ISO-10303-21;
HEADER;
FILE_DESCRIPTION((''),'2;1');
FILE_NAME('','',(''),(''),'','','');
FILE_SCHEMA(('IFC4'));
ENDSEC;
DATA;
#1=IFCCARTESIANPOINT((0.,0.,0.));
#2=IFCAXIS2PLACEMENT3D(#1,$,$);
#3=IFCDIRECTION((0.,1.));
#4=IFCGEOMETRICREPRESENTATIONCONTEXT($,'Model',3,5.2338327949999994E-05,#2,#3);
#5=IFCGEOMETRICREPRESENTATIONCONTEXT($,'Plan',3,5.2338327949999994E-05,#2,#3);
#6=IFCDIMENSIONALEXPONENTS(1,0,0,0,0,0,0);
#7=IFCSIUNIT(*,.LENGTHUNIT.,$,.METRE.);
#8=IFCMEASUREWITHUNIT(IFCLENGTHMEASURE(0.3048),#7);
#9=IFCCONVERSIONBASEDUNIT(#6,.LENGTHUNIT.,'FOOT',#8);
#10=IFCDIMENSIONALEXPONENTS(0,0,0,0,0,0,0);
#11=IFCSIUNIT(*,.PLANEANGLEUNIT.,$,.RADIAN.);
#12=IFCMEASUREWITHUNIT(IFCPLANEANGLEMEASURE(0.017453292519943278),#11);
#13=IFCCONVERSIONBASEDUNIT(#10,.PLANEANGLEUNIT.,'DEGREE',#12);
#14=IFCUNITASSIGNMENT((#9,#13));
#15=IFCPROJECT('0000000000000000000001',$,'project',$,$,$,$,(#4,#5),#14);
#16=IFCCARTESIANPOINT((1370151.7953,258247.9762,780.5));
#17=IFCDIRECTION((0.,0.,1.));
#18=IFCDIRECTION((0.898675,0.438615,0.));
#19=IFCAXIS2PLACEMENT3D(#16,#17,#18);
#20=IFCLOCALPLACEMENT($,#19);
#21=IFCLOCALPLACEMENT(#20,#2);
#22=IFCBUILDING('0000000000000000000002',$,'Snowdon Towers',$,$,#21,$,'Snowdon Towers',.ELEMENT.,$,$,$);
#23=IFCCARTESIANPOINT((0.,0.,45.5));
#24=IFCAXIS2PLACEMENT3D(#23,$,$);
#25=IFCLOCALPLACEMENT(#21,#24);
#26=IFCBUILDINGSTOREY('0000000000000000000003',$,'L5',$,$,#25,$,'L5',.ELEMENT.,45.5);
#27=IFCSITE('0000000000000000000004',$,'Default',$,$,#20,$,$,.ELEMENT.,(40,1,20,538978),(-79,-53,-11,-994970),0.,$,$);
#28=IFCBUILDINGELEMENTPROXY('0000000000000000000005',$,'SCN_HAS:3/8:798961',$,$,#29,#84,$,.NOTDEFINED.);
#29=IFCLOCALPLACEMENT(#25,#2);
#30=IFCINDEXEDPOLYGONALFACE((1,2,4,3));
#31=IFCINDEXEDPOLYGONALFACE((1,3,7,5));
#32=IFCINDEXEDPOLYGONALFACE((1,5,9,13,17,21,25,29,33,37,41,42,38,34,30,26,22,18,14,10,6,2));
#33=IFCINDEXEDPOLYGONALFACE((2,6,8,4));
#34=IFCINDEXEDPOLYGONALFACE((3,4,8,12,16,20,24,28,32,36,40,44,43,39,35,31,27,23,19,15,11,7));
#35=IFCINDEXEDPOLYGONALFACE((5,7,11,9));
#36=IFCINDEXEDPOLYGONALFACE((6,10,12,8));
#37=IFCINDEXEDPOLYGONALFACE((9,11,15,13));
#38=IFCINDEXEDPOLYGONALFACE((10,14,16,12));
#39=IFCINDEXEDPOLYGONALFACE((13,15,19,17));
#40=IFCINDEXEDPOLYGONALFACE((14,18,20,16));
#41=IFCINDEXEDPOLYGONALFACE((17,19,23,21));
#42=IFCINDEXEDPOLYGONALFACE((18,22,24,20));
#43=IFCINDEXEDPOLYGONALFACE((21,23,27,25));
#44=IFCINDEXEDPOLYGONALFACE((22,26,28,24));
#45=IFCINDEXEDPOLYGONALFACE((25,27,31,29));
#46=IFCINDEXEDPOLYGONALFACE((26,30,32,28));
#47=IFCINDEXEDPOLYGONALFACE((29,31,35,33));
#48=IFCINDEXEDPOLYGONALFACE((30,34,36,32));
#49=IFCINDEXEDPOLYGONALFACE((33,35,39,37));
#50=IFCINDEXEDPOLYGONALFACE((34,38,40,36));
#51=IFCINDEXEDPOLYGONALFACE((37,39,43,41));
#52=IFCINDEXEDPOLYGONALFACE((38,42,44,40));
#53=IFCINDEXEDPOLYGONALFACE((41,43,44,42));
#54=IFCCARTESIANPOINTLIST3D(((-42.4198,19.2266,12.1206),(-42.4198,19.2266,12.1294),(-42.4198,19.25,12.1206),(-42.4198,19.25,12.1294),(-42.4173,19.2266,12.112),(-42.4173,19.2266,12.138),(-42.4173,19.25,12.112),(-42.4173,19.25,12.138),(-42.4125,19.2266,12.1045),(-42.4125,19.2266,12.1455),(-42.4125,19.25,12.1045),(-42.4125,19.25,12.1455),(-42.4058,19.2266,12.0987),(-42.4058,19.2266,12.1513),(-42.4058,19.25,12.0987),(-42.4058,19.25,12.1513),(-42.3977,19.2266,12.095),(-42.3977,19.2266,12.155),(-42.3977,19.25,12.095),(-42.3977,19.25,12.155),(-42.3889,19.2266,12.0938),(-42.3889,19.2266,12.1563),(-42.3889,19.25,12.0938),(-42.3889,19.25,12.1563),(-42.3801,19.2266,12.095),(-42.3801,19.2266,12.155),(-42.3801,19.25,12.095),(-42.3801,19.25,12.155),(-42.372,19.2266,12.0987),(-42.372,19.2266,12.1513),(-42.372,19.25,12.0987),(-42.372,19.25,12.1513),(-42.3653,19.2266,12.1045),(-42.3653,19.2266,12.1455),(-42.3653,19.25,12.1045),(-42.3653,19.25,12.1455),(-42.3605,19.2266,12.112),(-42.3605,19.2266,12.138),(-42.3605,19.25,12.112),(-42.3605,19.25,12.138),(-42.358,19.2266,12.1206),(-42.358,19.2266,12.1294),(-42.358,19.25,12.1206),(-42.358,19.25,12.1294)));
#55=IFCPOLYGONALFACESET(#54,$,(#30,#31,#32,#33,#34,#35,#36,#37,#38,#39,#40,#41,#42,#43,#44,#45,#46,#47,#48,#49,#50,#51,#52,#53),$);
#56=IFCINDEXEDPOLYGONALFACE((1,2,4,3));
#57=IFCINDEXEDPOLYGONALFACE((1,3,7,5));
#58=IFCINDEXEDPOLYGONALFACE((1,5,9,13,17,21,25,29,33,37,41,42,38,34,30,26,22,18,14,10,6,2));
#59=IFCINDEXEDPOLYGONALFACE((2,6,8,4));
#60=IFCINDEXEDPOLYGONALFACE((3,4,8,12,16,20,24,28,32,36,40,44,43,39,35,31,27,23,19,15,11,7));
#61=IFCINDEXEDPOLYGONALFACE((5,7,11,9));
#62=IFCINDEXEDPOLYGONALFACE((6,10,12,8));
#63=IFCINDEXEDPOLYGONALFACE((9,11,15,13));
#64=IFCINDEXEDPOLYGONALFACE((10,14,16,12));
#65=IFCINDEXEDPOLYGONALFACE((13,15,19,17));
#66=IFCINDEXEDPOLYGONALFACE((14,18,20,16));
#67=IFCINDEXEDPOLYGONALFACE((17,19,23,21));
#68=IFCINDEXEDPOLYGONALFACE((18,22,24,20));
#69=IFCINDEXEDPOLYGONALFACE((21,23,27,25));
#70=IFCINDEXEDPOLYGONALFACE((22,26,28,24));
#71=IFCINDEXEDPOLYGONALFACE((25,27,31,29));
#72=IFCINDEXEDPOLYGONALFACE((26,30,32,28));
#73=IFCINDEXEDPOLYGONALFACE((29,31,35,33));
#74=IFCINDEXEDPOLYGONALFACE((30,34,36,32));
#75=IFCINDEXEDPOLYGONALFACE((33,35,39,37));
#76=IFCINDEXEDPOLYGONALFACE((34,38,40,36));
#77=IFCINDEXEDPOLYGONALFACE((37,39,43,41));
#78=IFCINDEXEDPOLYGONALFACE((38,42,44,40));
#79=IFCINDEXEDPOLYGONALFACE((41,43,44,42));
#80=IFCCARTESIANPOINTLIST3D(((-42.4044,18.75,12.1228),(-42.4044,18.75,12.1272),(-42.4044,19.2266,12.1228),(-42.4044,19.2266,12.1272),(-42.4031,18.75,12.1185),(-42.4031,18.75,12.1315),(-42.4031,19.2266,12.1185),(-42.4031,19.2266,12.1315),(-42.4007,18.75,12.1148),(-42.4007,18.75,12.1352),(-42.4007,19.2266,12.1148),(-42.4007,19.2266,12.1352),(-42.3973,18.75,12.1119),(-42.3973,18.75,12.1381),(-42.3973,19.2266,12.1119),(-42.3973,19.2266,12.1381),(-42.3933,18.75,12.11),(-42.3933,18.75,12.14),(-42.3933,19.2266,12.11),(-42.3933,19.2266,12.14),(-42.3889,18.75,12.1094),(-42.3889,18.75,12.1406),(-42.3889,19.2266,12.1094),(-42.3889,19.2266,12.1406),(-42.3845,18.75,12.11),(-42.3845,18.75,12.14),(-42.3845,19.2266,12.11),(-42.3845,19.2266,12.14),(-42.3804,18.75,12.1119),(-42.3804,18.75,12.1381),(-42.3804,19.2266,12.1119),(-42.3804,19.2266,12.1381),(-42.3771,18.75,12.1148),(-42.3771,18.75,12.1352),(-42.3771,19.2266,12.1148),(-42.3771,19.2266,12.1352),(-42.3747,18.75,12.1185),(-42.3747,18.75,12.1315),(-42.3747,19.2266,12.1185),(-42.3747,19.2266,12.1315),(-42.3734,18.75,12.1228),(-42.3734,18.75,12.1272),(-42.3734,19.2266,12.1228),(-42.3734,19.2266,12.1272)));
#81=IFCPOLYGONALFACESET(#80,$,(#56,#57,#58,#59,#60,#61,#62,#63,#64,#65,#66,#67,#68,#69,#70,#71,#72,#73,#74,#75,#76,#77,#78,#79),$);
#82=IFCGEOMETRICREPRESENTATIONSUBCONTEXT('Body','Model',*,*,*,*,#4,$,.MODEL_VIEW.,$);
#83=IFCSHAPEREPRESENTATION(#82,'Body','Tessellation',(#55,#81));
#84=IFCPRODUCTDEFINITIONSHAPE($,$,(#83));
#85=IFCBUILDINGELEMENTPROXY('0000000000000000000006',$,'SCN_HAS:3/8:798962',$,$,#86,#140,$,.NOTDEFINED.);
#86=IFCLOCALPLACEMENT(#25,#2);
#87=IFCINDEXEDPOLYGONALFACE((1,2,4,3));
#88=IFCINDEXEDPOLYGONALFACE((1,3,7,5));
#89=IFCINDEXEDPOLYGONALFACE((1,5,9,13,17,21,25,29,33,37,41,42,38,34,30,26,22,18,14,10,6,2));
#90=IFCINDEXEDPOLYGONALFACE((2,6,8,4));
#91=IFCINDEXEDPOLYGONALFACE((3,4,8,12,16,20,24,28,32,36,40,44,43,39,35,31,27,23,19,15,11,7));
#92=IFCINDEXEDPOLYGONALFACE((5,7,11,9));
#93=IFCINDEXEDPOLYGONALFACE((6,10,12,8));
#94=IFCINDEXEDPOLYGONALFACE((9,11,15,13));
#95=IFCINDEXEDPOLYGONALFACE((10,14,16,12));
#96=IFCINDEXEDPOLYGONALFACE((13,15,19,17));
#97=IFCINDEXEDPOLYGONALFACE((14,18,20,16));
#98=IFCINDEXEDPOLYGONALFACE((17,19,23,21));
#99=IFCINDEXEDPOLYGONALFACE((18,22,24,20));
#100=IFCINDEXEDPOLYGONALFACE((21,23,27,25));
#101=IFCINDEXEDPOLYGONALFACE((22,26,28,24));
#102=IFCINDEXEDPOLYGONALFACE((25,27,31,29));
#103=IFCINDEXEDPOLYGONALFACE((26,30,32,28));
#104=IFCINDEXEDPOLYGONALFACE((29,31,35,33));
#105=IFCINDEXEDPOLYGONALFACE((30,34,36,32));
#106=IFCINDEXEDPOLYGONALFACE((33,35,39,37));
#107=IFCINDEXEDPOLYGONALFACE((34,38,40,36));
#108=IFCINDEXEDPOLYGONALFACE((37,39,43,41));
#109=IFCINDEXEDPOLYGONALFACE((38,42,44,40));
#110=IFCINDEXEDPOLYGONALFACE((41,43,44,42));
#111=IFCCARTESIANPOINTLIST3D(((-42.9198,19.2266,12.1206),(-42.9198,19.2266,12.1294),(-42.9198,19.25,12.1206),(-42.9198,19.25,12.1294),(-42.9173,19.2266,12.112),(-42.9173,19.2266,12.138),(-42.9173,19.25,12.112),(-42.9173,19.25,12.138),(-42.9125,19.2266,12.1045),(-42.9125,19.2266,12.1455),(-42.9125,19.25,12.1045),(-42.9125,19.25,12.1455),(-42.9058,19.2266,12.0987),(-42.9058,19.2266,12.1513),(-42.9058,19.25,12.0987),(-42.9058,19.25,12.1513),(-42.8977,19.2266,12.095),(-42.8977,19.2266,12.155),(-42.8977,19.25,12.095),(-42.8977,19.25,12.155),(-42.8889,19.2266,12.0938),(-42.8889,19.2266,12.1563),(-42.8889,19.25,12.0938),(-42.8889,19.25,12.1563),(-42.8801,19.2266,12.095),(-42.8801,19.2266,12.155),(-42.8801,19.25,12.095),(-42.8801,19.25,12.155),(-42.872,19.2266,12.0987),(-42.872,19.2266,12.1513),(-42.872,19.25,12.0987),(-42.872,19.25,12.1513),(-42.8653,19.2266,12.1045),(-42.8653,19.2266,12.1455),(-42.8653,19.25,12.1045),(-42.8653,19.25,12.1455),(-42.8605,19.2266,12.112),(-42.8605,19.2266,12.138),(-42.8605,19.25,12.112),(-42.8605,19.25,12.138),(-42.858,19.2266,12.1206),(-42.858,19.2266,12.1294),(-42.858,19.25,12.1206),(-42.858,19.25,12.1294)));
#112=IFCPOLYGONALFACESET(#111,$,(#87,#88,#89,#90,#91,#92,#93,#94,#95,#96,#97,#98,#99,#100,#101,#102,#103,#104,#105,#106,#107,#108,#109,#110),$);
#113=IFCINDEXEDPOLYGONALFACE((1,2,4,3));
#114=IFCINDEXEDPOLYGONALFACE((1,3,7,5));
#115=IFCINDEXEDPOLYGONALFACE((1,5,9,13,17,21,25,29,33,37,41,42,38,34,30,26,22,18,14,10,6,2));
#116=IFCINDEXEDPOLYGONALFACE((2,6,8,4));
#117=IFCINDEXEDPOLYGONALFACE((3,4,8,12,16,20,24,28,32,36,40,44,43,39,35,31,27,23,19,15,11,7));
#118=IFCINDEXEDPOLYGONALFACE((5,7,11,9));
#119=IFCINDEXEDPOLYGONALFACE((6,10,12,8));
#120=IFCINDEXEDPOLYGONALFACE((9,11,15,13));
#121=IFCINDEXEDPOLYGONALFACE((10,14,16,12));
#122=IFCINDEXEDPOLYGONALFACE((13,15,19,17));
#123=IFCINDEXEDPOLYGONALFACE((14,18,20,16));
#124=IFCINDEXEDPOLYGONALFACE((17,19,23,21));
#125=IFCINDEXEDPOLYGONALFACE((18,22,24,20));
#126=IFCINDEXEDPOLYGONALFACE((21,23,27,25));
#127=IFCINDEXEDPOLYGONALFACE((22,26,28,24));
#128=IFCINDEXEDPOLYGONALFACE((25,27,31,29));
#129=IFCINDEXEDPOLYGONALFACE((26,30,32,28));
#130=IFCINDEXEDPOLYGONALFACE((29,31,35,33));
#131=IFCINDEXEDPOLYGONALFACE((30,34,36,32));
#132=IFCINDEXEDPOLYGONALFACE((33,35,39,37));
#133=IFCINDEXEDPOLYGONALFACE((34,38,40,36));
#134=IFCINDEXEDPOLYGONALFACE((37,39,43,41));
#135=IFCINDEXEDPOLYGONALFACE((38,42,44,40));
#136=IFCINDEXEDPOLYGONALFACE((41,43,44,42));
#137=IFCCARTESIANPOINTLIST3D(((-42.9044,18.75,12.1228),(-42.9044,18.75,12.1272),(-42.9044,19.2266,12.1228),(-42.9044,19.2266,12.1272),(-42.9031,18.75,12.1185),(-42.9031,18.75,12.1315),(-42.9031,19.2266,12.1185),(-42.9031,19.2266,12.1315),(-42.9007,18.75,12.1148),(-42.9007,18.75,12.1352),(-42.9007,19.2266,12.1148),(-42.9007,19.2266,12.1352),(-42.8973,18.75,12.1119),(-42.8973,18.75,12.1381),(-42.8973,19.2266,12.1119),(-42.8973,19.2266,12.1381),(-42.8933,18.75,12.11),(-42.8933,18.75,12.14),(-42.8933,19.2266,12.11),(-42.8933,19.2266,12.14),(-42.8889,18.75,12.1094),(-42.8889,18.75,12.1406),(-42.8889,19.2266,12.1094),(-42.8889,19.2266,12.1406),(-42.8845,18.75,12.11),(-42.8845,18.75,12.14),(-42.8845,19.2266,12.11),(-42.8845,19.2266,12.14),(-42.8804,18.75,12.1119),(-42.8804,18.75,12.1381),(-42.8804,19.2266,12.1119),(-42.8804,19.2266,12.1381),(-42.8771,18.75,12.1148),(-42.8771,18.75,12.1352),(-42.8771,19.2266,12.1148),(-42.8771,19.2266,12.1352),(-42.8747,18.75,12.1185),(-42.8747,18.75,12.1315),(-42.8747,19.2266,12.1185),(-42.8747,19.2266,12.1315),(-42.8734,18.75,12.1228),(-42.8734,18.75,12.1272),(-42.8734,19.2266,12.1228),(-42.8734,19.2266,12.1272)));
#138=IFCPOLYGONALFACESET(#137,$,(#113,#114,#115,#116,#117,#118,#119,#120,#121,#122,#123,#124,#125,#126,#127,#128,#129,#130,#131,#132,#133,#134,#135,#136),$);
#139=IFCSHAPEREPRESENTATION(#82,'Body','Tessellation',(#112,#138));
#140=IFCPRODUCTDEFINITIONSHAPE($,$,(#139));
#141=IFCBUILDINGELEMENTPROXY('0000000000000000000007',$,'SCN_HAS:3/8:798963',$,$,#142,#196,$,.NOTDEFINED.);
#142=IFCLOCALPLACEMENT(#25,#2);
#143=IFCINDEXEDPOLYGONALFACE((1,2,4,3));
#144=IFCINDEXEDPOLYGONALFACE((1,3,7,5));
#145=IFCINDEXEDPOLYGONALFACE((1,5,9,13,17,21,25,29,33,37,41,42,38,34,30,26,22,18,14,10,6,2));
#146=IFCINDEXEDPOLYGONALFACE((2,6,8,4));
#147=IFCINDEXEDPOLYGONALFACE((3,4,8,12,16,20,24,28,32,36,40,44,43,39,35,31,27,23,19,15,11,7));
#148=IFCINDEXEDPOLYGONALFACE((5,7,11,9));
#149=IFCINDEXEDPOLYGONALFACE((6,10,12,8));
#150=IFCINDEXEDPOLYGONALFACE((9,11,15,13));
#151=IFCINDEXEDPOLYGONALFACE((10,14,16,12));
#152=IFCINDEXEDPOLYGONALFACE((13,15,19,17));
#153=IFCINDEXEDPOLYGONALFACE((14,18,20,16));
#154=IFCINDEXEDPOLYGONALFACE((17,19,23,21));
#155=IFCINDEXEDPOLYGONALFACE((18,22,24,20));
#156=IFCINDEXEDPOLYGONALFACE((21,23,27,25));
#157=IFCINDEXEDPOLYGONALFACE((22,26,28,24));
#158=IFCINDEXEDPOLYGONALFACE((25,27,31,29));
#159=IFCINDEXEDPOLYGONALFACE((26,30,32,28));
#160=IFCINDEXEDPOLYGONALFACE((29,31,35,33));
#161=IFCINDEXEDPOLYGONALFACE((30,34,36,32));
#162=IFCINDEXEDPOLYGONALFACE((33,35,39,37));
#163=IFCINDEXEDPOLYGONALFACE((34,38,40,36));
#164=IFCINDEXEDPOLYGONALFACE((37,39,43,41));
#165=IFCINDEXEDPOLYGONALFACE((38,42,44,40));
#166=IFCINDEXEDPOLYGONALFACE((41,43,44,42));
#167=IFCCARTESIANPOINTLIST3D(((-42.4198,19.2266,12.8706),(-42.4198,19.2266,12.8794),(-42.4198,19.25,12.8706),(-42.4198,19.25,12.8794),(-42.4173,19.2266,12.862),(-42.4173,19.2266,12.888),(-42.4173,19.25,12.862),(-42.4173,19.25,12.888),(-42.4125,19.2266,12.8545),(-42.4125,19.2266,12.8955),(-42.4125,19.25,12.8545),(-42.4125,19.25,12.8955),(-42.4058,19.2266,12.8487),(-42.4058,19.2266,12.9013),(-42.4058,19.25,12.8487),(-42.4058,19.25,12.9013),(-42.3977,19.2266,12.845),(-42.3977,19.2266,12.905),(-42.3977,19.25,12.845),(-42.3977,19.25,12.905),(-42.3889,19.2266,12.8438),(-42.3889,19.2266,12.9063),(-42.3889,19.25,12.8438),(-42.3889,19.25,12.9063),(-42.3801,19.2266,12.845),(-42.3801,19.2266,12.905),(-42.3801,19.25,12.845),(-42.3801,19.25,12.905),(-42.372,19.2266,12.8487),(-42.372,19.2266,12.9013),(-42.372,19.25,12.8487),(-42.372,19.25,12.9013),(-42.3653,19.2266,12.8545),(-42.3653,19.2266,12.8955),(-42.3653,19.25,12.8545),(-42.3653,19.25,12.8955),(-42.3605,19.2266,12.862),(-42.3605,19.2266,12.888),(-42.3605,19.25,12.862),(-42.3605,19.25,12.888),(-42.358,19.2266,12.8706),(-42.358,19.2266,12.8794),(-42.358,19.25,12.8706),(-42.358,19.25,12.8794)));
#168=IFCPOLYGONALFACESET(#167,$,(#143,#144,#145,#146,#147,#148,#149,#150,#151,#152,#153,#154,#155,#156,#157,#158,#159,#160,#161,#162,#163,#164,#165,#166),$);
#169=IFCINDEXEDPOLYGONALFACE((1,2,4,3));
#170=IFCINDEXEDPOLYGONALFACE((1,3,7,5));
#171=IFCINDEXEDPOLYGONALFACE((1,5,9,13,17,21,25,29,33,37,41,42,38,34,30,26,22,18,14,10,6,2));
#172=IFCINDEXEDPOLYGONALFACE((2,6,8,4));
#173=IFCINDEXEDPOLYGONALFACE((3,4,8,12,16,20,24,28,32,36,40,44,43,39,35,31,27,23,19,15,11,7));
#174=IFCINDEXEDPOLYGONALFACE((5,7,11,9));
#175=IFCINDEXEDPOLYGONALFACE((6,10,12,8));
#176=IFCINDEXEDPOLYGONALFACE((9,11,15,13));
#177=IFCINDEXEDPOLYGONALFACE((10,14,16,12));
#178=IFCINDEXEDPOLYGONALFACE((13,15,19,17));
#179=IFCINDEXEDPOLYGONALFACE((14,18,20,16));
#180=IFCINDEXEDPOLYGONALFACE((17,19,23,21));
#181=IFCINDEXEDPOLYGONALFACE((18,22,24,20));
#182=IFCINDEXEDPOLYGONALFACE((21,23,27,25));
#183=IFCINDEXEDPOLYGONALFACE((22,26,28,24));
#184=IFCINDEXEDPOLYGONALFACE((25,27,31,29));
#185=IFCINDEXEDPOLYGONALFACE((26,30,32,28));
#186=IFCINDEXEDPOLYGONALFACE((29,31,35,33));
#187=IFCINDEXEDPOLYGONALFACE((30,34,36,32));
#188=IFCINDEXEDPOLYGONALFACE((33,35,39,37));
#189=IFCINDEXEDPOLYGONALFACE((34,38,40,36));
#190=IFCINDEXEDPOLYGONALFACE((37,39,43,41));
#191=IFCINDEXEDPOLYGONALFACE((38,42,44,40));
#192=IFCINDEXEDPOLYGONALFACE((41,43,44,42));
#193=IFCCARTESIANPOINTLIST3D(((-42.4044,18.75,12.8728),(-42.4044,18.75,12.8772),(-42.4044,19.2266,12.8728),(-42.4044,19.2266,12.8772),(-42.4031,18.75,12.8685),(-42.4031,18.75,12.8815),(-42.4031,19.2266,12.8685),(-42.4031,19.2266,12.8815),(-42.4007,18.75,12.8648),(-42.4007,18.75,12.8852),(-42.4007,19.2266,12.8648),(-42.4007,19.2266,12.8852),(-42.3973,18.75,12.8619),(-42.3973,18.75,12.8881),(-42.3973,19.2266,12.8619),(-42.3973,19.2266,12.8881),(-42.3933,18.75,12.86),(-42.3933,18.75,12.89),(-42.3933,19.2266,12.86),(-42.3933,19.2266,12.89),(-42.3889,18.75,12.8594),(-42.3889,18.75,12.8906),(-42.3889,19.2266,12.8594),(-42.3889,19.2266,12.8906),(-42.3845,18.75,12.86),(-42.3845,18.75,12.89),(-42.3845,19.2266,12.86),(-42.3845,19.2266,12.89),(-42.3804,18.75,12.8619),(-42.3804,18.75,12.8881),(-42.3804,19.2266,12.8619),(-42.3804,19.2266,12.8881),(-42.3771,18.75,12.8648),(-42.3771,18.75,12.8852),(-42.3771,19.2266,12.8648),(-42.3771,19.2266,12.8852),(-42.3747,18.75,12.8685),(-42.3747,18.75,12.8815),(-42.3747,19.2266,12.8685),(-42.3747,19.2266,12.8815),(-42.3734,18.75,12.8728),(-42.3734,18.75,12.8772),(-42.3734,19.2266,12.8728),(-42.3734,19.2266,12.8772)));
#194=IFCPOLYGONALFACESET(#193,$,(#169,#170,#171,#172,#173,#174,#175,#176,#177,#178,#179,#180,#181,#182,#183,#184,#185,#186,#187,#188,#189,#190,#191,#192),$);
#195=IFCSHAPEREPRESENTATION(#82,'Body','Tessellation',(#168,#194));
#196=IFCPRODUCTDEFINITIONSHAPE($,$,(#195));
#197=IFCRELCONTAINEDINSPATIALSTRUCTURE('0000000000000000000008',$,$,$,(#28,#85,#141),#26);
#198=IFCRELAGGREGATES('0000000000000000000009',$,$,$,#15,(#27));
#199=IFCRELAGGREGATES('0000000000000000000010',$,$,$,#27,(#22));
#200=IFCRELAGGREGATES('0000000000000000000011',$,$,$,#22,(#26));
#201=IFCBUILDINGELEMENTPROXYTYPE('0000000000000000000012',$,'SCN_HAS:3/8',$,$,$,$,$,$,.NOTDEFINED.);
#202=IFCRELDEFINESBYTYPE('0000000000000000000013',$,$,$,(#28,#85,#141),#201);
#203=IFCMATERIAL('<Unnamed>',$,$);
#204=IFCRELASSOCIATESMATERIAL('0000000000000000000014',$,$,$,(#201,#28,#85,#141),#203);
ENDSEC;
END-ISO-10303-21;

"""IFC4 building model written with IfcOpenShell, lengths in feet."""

from ifc_helpers import new_model, entity, si_unit, converted_unit, direction, frame, origin, place, context, subcontext, project, spatial, arc, indexed_curve, outline, extrude, source, transform, mapped, material, type_object, type_shapes, element, save


model = new_model("IFC4")

# Units and contexts
model_context = context("Model", 3, precision=5.2338327949999994e-05, world=origin(), true_north=direction((0.0, 1.0)))
plan_context = context("Plan", 3, precision=5.2338327949999994e-05, world=origin(), true_north=direction((0.0, 1.0)))
body_context = subcontext(model_context, "Body", "Model", "MODEL_VIEW")
ifc_project = project(units=[converted_unit("LENGTHUNIT", "FOOT", entity("IfcLengthMeasure", 0.3048), si_unit("LENGTHUNIT", "METRE"), dimensions=[1, 0, 0, 0, 0, 0, 0]), converted_unit("PLANEANGLEUNIT", "DEGREE", entity("IfcPlaneAngleMeasure", 0.017453292519943278), si_unit("PLANEANGLEUNIT", "RADIAN"), dimensions=[0, 0, 0, 0, 0, 0, 0])], contexts=[model_context, plan_context])

# Site, building, storey
site_placement = place(None, frame((1370151.7953, 258247.9762, 780.5), z_axis=(0.0, 0.0, 1.0), x_axis=(0.898675, 0.438615, 0.0)))
site = spatial("IfcSite", under=ifc_project, at=site_placement, Name="Default", CompositionType="ELEMENT", RefLatitude=(40, 1, 20, 538978), RefLongitude=(-79, -53, -11, -994970), RefElevation=0.0)
building_placement = place(site_placement, origin())
building = spatial("IfcBuilding", under=site, at=building_placement, Name="Snowdon Towers", LongName="Snowdon Towers", CompositionType="ELEMENT")
storey_placement = place(building_placement, frame((0.0, 0.0, 45.5)))
storey = spatial("IfcBuildingStorey", under=building, at=storey_placement, Name="L5", LongName="L5", CompositionType="ELEMENT", Elevation=45.5)

# Building element proxies
ifc_material_1 = material(Name="<Unnamed>")
building_element_proxy_type_1 = type_object("IfcBuildingElementProxyType", Name="SCN_HAS:3/8", PredefinedType="NOTDEFINED", material=ifc_material_1)
shared_shape_1 = source(origin(), body_context, "Body", "SweptSolid", [
    extrude(outline(indexed_curve([(-0.0312, 0.0), (0.0, -0.0313), (0.0312, 0.0), (0.0, 0.0312)], segments=[arc(1, 2, 3), arc(3, 4, 1)], self_intersect=False)), frame((0.0, 0.0, -0.5), z_axis=(0.0, 0.0, 1.0), x_axis=(0.0, -1.0, 0.0)), (0.0, 0.0, 1.0), 0.0234),
    extrude(outline(indexed_curve([(-0.0156, 0.0), (0.0, -0.0156), (0.0156, 0.0), (0.0, 0.0156)], segments=[arc(1, 2, 3), arc(3, 4, 1)], self_intersect=False)), frame((0.0, 0.0, -0.4766), z_axis=(0.0, 0.0, 1.0), x_axis=(0.0, -1.0, 0.0)), (0.0, 0.0, 1.0), 0.4766),
])
type_shapes(building_element_proxy_type_1, [shared_shape_1])
for number, where, z_axis, x_axis, name in (
    (1, (-42.3889, 18.75, 12.125), (0.0, -1.0, 0.0), (1.0, 0.0, 0.0), "SCN_HAS:3/8:798961"),
    (2, (-42.8889, 18.75, 12.125), (0.0, -1.0, 0.0), (1.0, 0.0, 0.0), "SCN_HAS:3/8:798962"),
    (3, (-42.3889, 18.75, 12.875), (0.0, -1.0, 0.0), (1.0, 0.0, 0.0), "SCN_HAS:3/8:798963"),
):
    element("IfcBuildingElementProxy", number, at=place(storey_placement, frame(where, z_axis=z_axis, x_axis=x_axis)), inside=storey, type_object=building_element_proxy_type_1, material=ifc_material_1, Name=name, PredefinedType="NOTDEFINED", context=body_context, shape_type="MappedRepresentation", body=[
        mapped(shared_shape_1, transform((0.0, 0.0, 0.0), scale=1.0)),
    ])

save(model, "model.ifc")
